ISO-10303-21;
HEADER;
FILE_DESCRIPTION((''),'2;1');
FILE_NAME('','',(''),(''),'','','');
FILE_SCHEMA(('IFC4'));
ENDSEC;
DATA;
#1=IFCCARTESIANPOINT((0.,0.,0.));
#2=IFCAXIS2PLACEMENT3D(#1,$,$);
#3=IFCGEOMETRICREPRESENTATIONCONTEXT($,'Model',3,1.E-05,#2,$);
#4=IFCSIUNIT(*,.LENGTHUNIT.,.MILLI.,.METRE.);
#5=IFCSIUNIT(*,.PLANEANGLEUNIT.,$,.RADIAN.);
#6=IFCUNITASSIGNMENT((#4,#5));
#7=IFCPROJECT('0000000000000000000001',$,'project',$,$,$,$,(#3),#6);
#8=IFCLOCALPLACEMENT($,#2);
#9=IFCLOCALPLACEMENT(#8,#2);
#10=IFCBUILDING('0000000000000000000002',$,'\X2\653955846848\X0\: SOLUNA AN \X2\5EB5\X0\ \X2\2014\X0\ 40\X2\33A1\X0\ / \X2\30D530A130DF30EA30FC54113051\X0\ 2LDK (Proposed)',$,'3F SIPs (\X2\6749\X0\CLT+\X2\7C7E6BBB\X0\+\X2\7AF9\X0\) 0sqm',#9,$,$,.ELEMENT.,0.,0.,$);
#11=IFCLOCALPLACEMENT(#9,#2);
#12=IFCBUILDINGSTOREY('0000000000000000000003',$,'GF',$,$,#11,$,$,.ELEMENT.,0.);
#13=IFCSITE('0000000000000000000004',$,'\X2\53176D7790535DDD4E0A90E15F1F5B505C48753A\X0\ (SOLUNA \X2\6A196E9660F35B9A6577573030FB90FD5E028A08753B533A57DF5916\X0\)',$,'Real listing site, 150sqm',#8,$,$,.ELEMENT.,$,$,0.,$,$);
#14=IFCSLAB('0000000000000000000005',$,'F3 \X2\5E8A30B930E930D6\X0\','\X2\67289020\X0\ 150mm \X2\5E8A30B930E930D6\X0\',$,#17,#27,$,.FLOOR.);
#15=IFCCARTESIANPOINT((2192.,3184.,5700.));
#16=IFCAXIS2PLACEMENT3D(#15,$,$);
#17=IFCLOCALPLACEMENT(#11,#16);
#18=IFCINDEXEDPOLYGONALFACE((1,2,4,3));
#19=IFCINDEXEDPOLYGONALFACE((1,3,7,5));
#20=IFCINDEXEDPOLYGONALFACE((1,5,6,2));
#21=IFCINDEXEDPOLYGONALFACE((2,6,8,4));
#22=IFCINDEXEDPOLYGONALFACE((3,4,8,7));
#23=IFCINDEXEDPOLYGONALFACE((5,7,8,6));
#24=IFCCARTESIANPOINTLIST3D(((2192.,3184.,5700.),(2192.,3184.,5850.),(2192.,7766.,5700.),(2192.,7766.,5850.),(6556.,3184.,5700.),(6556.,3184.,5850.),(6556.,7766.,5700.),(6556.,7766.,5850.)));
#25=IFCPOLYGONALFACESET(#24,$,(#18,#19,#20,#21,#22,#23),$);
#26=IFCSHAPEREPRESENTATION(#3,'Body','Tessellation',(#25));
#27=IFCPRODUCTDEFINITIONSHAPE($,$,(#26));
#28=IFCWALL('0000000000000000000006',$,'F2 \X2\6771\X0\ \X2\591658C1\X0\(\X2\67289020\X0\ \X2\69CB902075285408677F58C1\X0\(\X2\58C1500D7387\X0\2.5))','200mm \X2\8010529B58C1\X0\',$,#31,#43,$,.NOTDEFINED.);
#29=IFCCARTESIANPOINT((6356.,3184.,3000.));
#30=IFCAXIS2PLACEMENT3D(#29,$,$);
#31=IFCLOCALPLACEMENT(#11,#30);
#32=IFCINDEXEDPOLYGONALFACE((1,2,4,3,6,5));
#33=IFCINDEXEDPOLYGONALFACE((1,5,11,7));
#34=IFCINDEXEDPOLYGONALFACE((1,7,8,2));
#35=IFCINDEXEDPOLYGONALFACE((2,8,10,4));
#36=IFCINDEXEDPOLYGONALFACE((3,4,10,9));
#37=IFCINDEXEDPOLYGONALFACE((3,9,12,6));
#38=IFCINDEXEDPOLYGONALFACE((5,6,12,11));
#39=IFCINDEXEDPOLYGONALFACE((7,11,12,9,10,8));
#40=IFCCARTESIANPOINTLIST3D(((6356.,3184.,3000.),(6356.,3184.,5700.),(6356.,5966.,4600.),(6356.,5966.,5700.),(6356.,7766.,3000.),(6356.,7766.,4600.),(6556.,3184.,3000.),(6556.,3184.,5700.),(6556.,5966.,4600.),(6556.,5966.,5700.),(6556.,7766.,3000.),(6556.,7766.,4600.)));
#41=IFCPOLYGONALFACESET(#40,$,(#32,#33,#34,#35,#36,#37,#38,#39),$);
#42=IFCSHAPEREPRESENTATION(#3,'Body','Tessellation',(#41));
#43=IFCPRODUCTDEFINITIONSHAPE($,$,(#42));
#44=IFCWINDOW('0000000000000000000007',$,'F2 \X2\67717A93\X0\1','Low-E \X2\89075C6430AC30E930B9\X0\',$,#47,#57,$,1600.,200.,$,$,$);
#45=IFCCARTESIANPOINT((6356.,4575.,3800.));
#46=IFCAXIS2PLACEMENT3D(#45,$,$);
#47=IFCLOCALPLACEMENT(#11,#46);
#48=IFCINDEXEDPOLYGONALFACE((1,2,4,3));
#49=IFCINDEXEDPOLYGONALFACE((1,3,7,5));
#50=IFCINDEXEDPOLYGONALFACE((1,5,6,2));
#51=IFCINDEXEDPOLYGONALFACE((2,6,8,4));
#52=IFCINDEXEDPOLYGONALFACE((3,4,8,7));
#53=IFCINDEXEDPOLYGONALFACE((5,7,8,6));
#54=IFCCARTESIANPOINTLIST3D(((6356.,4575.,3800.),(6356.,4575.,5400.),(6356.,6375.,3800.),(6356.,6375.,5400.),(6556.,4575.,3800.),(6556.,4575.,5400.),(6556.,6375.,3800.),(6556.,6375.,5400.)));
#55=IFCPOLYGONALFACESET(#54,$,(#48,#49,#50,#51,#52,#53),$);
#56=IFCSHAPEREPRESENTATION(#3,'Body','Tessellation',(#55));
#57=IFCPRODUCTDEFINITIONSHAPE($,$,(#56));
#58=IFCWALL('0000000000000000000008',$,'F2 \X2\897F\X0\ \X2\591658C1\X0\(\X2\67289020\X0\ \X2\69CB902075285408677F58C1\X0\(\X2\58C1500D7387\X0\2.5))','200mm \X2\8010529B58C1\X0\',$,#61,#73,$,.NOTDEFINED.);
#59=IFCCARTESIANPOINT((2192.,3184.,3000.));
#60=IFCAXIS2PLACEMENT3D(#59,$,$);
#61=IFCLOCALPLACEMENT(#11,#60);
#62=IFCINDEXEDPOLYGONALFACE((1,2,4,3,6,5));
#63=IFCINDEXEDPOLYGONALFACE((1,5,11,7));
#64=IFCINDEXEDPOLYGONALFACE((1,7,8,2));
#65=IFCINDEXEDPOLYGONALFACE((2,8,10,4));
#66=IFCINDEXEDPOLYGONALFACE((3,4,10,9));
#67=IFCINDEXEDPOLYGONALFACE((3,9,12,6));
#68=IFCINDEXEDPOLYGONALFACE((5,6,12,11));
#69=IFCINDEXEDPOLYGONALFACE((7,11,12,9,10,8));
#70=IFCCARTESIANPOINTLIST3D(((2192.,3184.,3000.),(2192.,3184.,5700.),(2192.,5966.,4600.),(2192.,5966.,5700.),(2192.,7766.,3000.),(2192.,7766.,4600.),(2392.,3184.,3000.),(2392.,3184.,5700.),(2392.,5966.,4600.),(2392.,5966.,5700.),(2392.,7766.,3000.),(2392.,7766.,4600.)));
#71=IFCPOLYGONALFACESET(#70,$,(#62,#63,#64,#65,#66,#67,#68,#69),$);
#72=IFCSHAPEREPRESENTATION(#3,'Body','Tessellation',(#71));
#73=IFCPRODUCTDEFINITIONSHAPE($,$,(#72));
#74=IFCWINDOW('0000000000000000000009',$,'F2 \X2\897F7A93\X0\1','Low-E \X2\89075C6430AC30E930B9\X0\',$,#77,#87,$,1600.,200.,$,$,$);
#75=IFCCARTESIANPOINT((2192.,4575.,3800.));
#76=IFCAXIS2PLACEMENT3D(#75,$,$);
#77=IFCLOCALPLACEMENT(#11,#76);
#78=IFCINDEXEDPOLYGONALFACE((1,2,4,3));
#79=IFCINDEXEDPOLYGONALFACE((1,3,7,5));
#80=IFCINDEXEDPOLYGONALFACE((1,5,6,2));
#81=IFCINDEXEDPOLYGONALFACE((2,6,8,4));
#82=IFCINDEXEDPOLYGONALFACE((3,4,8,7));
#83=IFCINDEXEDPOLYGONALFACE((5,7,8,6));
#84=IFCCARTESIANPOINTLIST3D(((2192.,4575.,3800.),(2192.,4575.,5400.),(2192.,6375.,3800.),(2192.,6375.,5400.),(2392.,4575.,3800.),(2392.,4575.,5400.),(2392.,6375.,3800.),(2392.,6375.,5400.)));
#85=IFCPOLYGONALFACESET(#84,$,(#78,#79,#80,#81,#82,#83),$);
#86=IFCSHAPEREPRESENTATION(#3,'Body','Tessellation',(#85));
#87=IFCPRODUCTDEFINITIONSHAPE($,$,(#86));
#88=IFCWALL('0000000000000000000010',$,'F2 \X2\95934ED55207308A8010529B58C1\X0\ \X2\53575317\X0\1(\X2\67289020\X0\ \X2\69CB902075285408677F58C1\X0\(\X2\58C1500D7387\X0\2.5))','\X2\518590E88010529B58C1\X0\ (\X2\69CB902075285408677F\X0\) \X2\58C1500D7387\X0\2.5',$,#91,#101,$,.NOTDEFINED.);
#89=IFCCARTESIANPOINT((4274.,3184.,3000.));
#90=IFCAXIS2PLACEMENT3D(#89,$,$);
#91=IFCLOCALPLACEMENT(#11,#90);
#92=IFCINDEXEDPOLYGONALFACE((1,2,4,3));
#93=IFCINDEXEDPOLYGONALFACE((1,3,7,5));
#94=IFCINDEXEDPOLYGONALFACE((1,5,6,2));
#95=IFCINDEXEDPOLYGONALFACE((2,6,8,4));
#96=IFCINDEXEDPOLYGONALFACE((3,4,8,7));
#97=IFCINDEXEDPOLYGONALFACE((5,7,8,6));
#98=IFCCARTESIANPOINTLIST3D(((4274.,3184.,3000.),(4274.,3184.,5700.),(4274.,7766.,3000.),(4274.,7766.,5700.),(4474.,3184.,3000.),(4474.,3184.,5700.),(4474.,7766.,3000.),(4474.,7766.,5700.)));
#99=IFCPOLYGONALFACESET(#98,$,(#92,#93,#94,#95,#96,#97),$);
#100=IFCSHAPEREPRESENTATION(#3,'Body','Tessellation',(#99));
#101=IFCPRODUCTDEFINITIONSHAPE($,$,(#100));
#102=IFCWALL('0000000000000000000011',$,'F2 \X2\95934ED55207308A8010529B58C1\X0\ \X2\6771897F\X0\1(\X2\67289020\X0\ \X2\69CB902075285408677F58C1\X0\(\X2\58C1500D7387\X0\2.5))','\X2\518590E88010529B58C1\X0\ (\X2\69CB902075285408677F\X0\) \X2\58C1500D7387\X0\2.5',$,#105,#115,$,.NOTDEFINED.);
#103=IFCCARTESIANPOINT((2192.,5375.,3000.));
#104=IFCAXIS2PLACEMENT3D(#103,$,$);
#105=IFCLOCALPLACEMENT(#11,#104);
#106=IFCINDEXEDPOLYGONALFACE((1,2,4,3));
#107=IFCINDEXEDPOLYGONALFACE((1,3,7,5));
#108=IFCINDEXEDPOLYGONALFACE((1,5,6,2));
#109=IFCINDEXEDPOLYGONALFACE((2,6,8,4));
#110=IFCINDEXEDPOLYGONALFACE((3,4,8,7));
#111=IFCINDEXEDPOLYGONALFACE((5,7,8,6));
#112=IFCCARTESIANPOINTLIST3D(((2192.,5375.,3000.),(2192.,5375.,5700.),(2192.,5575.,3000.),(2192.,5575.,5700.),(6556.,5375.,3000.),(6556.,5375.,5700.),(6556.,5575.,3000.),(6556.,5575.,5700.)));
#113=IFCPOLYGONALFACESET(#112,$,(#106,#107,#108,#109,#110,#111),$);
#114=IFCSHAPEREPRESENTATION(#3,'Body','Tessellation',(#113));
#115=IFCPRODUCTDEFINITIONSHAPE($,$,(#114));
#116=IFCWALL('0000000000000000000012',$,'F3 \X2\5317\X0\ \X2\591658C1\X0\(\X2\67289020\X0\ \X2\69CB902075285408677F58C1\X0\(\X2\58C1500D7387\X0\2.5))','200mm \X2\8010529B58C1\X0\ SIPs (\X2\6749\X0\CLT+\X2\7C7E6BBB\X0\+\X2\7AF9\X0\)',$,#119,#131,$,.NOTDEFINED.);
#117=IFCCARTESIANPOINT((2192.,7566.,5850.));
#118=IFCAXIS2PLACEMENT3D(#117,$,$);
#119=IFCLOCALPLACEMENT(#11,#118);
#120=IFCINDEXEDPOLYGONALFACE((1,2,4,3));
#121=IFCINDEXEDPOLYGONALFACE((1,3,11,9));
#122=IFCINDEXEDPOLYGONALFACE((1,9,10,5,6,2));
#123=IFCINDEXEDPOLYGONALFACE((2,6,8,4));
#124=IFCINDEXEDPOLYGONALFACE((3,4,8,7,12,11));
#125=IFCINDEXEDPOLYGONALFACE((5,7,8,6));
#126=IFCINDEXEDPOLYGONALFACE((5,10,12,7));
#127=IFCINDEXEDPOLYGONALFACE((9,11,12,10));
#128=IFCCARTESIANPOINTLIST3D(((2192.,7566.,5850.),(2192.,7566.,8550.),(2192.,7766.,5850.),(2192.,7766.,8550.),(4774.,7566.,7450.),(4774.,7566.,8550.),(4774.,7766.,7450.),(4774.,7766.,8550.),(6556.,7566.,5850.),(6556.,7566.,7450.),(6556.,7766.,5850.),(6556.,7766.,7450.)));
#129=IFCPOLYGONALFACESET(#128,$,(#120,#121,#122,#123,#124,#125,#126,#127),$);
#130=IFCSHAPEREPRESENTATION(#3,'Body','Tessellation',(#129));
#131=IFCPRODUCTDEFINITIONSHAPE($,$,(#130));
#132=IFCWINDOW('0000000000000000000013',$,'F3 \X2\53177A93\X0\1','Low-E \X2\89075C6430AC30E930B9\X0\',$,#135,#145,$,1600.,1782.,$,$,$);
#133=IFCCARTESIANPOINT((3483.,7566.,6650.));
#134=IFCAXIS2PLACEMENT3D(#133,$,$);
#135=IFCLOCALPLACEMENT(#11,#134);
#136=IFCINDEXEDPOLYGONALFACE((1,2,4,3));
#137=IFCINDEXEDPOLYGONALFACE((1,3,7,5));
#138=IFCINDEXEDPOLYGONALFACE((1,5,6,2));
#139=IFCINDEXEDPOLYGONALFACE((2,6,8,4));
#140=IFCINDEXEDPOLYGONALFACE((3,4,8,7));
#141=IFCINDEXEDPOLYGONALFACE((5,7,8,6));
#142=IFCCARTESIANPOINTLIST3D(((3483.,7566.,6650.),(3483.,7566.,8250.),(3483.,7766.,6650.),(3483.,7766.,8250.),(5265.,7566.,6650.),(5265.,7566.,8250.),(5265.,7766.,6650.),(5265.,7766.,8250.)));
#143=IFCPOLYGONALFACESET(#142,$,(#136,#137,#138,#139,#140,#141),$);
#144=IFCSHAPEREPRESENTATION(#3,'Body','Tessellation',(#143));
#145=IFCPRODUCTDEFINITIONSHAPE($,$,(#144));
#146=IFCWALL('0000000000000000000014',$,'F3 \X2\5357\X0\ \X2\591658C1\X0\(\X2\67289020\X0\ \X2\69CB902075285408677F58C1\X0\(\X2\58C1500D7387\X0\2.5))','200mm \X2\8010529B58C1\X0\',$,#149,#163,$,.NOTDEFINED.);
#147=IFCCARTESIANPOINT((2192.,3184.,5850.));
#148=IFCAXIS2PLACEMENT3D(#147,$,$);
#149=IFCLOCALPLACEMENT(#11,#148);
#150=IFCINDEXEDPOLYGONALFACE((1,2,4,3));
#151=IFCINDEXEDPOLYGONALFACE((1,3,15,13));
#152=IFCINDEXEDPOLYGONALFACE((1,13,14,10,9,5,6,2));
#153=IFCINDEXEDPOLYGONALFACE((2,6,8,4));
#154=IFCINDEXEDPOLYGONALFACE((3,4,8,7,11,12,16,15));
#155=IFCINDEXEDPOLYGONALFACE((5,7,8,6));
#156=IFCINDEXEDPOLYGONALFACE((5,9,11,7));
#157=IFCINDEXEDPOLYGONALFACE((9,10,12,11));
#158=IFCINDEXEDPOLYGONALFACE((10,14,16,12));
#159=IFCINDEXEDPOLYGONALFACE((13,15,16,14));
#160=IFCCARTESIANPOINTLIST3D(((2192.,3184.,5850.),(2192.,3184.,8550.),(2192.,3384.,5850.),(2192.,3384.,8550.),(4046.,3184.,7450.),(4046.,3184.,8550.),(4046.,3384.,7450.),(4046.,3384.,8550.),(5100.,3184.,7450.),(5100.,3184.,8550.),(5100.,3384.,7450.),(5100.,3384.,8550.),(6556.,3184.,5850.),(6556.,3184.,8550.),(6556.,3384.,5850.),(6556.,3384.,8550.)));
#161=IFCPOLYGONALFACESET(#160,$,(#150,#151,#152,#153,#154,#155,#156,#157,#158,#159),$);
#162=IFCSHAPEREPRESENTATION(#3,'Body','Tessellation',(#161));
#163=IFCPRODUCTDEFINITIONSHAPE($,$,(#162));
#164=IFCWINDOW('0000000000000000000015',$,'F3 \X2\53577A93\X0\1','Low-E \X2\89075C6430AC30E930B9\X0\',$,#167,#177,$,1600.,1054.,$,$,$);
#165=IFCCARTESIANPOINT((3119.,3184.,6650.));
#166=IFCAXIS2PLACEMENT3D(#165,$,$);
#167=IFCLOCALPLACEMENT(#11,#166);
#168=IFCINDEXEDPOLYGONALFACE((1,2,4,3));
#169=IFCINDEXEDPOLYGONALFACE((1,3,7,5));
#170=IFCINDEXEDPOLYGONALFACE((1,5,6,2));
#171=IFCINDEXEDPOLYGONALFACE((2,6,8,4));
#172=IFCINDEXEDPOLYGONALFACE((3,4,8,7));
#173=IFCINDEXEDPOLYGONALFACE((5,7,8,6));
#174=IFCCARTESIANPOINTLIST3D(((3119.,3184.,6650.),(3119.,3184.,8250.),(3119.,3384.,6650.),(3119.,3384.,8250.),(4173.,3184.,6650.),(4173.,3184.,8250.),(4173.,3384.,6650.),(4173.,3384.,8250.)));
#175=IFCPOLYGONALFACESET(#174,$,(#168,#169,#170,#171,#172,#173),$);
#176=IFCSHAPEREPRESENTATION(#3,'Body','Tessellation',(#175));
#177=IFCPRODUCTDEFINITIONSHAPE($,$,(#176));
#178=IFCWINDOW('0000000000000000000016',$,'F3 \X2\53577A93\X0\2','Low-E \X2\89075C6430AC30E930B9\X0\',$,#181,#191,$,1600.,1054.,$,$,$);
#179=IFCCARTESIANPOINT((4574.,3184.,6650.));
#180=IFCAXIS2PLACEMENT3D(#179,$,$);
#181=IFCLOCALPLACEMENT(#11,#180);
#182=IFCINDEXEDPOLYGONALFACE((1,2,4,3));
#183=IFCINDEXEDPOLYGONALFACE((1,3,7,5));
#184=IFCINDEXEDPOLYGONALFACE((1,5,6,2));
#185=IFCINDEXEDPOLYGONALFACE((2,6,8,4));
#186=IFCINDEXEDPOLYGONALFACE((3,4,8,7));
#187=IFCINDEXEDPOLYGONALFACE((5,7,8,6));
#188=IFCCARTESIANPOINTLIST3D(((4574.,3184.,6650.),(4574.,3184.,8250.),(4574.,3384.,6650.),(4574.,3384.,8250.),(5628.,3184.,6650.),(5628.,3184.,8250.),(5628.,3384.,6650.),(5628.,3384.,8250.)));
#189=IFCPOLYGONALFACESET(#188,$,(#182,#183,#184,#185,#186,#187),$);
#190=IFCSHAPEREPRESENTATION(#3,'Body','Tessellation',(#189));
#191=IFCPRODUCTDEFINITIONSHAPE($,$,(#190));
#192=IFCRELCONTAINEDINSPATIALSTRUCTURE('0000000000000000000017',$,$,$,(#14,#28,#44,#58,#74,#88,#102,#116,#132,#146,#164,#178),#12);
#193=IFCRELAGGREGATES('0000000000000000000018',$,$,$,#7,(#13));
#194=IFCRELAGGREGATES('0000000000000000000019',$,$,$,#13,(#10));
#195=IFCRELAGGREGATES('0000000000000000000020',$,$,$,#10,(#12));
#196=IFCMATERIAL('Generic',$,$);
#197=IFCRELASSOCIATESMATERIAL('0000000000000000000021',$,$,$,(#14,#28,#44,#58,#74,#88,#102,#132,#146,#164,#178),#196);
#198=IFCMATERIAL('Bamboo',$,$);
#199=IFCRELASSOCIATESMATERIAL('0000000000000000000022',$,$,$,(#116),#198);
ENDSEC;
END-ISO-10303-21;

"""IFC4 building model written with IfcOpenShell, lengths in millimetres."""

from ifc_helpers import new_model, si_unit, frame, frame_2d, origin, place, context, project, spatial, rectangle, extrude, material, element, fill, save


model = new_model("IFC4")

# Units and contexts
model_context = context("Model", 3, precision=1e-05, world=origin())
ifc_project = project(units=[si_unit("LENGTHUNIT", "METRE", prefix="MILLI"), si_unit("PLANEANGLEUNIT", "RADIAN")], contexts=[model_context])

# Site, building, storey
site_placement = place(None, origin())
site = spatial("IfcSite", under=ifc_project, at=site_placement, Name="北海道川上郡弟子屈町 (SOLUNA 標準想定敷地・都市計画区域外)", ObjectType="Real listing site, 150sqm", CompositionType="ELEMENT", RefElevation=0.0)
building_placement = place(site_placement, origin())
building = spatial("IfcBuilding", under=site, at=building_placement, Name="改善案: SOLUNA AN 庵 — 40㎡ / ファミリー向け 2LDK (Proposed)", ObjectType="3F SIPs (杉CLT+籾殻+竹) 0sqm", CompositionType="ELEMENT", ElevationOfRefHeight=0.0, ElevationOfTerrain=0.0)
storey_placement = place(building_placement, origin())
storey = spatial("IfcBuildingStorey", under=building, at=storey_placement, Name="GF", CompositionType="ELEMENT", Elevation=0.0)

# Slab
ifc_material_1 = material(Name="Generic")
slab_placement = place(storey_placement, frame((2192.0, 3184.0, 5700.0)))
element("IfcSlab", 1, at=slab_placement, inside=storey, material=ifc_material_1, Name="F3 床スラブ", Description="木造 150mm 床スラブ", PredefinedType="FLOOR", context=model_context, shape_type="SweptSolid", body=[
    extrude(rectangle(XDim=4364.0, YDim=4582.0, at=frame_2d((2182.0, 2291.0))), frame((2192.0, 3184.0, 5700.0)), (0.0, 0.0, 1.0), 150.0),
])

# Walls, openings, windows
wall_1_placement = place(storey_placement, frame((6356.0, 3184.0, 3000.0)))
wall_1 = element("IfcWall", 2, at=wall_1_placement, inside=storey, material=ifc_material_1, Name="F2 東 外壁(木造 構造用合板壁(壁倍率2.5))", Description="200mm 耐力壁", PredefinedType="NOTDEFINED", context=model_context, shape_type="SweptSolid", body=[
    extrude(rectangle(XDim=200.0, YDim=4582.0, at=frame_2d((100.0, 2291.0))), frame((6356.0, 3184.0, 3000.0)), (0.0, 0.0, 1.0), 2700.0),
])
opening_1_placement = place(storey_placement, frame((6356.0, 4575.0, 3800.0)))
opening_1 = element("IfcOpeningElement", 3, at=opening_1_placement, cuts=wall_1, PredefinedType="NOTDEFINED", context=model_context, shape_type="SweptSolid", body=[
    extrude(rectangle(XDim=200.0, YDim=1800.0, at=frame_2d((100.0, 900.0))), frame((6356.0, 4575.0, 3800.0)), (0.0, 0.0, 1.0), 1600.0),
])
window_1_placement = place(storey_placement, frame((6356.0, 4575.0, 3800.0)))
window_1 = element("IfcWindow", 4, at=window_1_placement, inside=storey, material=ifc_material_1, Name="F2 東窓1", Description="Low-E 複層ガラス", OverallHeight=1600.0, OverallWidth=200.0, context=model_context, shape_type="SweptSolid", body=[
    extrude(rectangle(XDim=200.0, YDim=1800.0, at=frame_2d((100.0, 900.0))), frame((6356.0, 4575.0, 3800.0)), (0.0, 0.0, 1.0), 1600.0),
])
fill(opening_1, window_1)
wall_2_placement = place(storey_placement, frame((2192.0, 3184.0, 3000.0)))
wall_2 = element("IfcWall", 5, at=wall_2_placement, inside=storey, material=ifc_material_1, Name="F2 西 外壁(木造 構造用合板壁(壁倍率2.5))", Description="200mm 耐力壁", PredefinedType="NOTDEFINED", context=model_context, shape_type="SweptSolid", body=[
    extrude(rectangle(XDim=200.0, YDim=4582.0, at=frame_2d((100.0, 2291.0))), frame((2192.0, 3184.0, 3000.0)), (0.0, 0.0, 1.0), 2700.0),
])
opening_2_placement = place(storey_placement, frame((2192.0, 4575.0, 3800.0)))
opening_2 = element("IfcOpeningElement", 6, at=opening_2_placement, cuts=wall_2, PredefinedType="NOTDEFINED", context=model_context, shape_type="SweptSolid", body=[
    extrude(rectangle(XDim=200.0, YDim=1800.0, at=frame_2d((100.0, 900.0))), frame((2192.0, 4575.0, 3800.0)), (0.0, 0.0, 1.0), 1600.0),
])
window_2_placement = place(storey_placement, frame((2192.0, 4575.0, 3800.0)))
window_2 = element("IfcWindow", 7, at=window_2_placement, inside=storey, material=ifc_material_1, Name="F2 西窓1", Description="Low-E 複層ガラス", OverallHeight=1600.0, OverallWidth=200.0, context=model_context, shape_type="SweptSolid", body=[
    extrude(rectangle(XDim=200.0, YDim=1800.0, at=frame_2d((100.0, 900.0))), frame((2192.0, 4575.0, 3800.0)), (0.0, 0.0, 1.0), 1600.0),
])
fill(opening_2, window_2)

# Walls
wall_3_placement = place(storey_placement, frame((4274.0, 3184.0, 3000.0)))
element("IfcWall", 8, at=wall_3_placement, inside=storey, material=ifc_material_1, Name="F2 間仕切り耐力壁 南北1(木造 構造用合板壁(壁倍率2.5))", Description="内部耐力壁 (構造用合板) 壁倍率2.5", PredefinedType="NOTDEFINED", context=model_context, shape_type="SweptSolid", body=[
    extrude(rectangle(XDim=200.0, YDim=4582.0, at=frame_2d((100.0, 2291.0))), frame((4274.0, 3184.0, 3000.0)), (0.0, 0.0, 1.0), 2700.0),
])
wall_4_placement = place(storey_placement, frame((2192.0, 5375.0, 3000.0)))
element("IfcWall", 9, at=wall_4_placement, inside=storey, material=ifc_material_1, Name="F2 間仕切り耐力壁 東西1(木造 構造用合板壁(壁倍率2.5))", Description="内部耐力壁 (構造用合板) 壁倍率2.5", PredefinedType="NOTDEFINED", context=model_context, shape_type="SweptSolid", body=[
    extrude(rectangle(XDim=4364.0, YDim=200.0, at=frame_2d((2182.0, 100.0))), frame((2192.0, 5375.0, 3000.0)), (0.0, 0.0, 1.0), 2700.0),
])

# Wall, opening, window
ifc_material_2 = material(Name="Bamboo")
wall_5_placement = place(storey_placement, frame((2192.0, 7566.0, 5850.0)))
wall_5 = element("IfcWall", 10, at=wall_5_placement, inside=storey, material=ifc_material_2, Name="F3 北 外壁(木造 構造用合板壁(壁倍率2.5))", Description="200mm 耐力壁 SIPs (杉CLT+籾殻+竹)", PredefinedType="NOTDEFINED", context=model_context, shape_type="SweptSolid", body=[
    extrude(rectangle(XDim=4364.0, YDim=200.0, at=frame_2d((2182.0, 100.0))), frame((2192.0, 7566.0, 5850.0)), (0.0, 0.0, 1.0), 2700.0),
])
opening_3_placement = place(storey_placement, frame((3483.0, 7566.0, 6650.0)))
opening_3 = element("IfcOpeningElement", 11, at=opening_3_placement, cuts=wall_5, PredefinedType="NOTDEFINED", context=model_context, shape_type="SweptSolid", body=[
    extrude(rectangle(XDim=1782.0, YDim=200.0, at=frame_2d((891.0, 100.0))), frame((3483.0, 7566.0, 6650.0)), (0.0, 0.0, 1.0), 1600.0),
])
window_3_placement = place(storey_placement, frame((3483.0, 7566.0, 6650.0)))
window_3 = element("IfcWindow", 12, at=window_3_placement, inside=storey, material=ifc_material_1, Name="F3 北窓1", Description="Low-E 複層ガラス", OverallHeight=1600.0, OverallWidth=1782.0, context=model_context, shape_type="SweptSolid", body=[
    extrude(rectangle(XDim=1782.0, YDim=200.0, at=frame_2d((891.0, 100.0))), frame((3483.0, 7566.0, 6650.0)), (0.0, 0.0, 1.0), 1600.0),
])
fill(opening_3, window_3)

# Wall, openings, windows
wall_6_placement = place(storey_placement, frame((2192.0, 3184.0, 5850.0)))
wall_6 = element("IfcWall", 13, at=wall_6_placement, inside=storey, material=ifc_material_1, Name="F3 南 外壁(木造 構造用合板壁(壁倍率2.5))", Description="200mm 耐力壁", PredefinedType="NOTDEFINED", context=model_context, shape_type="SweptSolid", body=[
    extrude(rectangle(XDim=4364.0, YDim=200.0, at=frame_2d((2182.0, 100.0))), frame((2192.0, 3184.0, 5850.0)), (0.0, 0.0, 1.0), 2700.0),
])
opening_4_placement = place(storey_placement, frame((3119.0, 3184.0, 6650.0)))
opening_4 = element("IfcOpeningElement", 14, at=opening_4_placement, cuts=wall_6, PredefinedType="NOTDEFINED", context=model_context, shape_type="SweptSolid", body=[
    extrude(rectangle(XDim=1054.0, YDim=200.0, at=frame_2d((527.0, 100.0))), frame((3119.0, 3184.0, 6650.0)), (0.0, 0.0, 1.0), 1600.0),
])
opening_5_placement = place(storey_placement, frame((4574.0, 3184.0, 6650.0)))
opening_5 = element("IfcOpeningElement", 15, at=opening_5_placement, cuts=wall_6, PredefinedType="NOTDEFINED", context=model_context, shape_type="SweptSolid", body=[
    extrude(rectangle(XDim=1054.0, YDim=200.0, at=frame_2d((527.0, 100.0))), frame((4574.0, 3184.0, 6650.0)), (0.0, 0.0, 1.0), 1600.0),
])
window_4_placement = place(storey_placement, frame((3119.0, 3184.0, 6650.0)))
window_4 = element("IfcWindow", 16, at=window_4_placement, inside=storey, material=ifc_material_1, Name="F3 南窓1", Description="Low-E 複層ガラス", OverallHeight=1600.0, OverallWidth=1054.0, context=model_context, shape_type="SweptSolid", body=[
    extrude(rectangle(XDim=1054.0, YDim=200.0, at=frame_2d((527.0, 100.0))), frame((3119.0, 3184.0, 6650.0)), (0.0, 0.0, 1.0), 1600.0),
])
fill(opening_4, window_4)
window_5_placement = place(storey_placement, frame((4574.0, 3184.0, 6650.0)))
window_5 = element("IfcWindow", 17, at=window_5_placement, inside=storey, material=ifc_material_1, Name="F3 南窓2", Description="Low-E 複層ガラス", OverallHeight=1600.0, OverallWidth=1054.0, context=model_context, shape_type="SweptSolid", body=[
    extrude(rectangle(XDim=1054.0, YDim=200.0, at=frame_2d((527.0, 100.0))), frame((4574.0, 3184.0, 6650.0)), (0.0, 0.0, 1.0), 1600.0),
])
fill(opening_5, window_5)

save(model, "model.ifc")
